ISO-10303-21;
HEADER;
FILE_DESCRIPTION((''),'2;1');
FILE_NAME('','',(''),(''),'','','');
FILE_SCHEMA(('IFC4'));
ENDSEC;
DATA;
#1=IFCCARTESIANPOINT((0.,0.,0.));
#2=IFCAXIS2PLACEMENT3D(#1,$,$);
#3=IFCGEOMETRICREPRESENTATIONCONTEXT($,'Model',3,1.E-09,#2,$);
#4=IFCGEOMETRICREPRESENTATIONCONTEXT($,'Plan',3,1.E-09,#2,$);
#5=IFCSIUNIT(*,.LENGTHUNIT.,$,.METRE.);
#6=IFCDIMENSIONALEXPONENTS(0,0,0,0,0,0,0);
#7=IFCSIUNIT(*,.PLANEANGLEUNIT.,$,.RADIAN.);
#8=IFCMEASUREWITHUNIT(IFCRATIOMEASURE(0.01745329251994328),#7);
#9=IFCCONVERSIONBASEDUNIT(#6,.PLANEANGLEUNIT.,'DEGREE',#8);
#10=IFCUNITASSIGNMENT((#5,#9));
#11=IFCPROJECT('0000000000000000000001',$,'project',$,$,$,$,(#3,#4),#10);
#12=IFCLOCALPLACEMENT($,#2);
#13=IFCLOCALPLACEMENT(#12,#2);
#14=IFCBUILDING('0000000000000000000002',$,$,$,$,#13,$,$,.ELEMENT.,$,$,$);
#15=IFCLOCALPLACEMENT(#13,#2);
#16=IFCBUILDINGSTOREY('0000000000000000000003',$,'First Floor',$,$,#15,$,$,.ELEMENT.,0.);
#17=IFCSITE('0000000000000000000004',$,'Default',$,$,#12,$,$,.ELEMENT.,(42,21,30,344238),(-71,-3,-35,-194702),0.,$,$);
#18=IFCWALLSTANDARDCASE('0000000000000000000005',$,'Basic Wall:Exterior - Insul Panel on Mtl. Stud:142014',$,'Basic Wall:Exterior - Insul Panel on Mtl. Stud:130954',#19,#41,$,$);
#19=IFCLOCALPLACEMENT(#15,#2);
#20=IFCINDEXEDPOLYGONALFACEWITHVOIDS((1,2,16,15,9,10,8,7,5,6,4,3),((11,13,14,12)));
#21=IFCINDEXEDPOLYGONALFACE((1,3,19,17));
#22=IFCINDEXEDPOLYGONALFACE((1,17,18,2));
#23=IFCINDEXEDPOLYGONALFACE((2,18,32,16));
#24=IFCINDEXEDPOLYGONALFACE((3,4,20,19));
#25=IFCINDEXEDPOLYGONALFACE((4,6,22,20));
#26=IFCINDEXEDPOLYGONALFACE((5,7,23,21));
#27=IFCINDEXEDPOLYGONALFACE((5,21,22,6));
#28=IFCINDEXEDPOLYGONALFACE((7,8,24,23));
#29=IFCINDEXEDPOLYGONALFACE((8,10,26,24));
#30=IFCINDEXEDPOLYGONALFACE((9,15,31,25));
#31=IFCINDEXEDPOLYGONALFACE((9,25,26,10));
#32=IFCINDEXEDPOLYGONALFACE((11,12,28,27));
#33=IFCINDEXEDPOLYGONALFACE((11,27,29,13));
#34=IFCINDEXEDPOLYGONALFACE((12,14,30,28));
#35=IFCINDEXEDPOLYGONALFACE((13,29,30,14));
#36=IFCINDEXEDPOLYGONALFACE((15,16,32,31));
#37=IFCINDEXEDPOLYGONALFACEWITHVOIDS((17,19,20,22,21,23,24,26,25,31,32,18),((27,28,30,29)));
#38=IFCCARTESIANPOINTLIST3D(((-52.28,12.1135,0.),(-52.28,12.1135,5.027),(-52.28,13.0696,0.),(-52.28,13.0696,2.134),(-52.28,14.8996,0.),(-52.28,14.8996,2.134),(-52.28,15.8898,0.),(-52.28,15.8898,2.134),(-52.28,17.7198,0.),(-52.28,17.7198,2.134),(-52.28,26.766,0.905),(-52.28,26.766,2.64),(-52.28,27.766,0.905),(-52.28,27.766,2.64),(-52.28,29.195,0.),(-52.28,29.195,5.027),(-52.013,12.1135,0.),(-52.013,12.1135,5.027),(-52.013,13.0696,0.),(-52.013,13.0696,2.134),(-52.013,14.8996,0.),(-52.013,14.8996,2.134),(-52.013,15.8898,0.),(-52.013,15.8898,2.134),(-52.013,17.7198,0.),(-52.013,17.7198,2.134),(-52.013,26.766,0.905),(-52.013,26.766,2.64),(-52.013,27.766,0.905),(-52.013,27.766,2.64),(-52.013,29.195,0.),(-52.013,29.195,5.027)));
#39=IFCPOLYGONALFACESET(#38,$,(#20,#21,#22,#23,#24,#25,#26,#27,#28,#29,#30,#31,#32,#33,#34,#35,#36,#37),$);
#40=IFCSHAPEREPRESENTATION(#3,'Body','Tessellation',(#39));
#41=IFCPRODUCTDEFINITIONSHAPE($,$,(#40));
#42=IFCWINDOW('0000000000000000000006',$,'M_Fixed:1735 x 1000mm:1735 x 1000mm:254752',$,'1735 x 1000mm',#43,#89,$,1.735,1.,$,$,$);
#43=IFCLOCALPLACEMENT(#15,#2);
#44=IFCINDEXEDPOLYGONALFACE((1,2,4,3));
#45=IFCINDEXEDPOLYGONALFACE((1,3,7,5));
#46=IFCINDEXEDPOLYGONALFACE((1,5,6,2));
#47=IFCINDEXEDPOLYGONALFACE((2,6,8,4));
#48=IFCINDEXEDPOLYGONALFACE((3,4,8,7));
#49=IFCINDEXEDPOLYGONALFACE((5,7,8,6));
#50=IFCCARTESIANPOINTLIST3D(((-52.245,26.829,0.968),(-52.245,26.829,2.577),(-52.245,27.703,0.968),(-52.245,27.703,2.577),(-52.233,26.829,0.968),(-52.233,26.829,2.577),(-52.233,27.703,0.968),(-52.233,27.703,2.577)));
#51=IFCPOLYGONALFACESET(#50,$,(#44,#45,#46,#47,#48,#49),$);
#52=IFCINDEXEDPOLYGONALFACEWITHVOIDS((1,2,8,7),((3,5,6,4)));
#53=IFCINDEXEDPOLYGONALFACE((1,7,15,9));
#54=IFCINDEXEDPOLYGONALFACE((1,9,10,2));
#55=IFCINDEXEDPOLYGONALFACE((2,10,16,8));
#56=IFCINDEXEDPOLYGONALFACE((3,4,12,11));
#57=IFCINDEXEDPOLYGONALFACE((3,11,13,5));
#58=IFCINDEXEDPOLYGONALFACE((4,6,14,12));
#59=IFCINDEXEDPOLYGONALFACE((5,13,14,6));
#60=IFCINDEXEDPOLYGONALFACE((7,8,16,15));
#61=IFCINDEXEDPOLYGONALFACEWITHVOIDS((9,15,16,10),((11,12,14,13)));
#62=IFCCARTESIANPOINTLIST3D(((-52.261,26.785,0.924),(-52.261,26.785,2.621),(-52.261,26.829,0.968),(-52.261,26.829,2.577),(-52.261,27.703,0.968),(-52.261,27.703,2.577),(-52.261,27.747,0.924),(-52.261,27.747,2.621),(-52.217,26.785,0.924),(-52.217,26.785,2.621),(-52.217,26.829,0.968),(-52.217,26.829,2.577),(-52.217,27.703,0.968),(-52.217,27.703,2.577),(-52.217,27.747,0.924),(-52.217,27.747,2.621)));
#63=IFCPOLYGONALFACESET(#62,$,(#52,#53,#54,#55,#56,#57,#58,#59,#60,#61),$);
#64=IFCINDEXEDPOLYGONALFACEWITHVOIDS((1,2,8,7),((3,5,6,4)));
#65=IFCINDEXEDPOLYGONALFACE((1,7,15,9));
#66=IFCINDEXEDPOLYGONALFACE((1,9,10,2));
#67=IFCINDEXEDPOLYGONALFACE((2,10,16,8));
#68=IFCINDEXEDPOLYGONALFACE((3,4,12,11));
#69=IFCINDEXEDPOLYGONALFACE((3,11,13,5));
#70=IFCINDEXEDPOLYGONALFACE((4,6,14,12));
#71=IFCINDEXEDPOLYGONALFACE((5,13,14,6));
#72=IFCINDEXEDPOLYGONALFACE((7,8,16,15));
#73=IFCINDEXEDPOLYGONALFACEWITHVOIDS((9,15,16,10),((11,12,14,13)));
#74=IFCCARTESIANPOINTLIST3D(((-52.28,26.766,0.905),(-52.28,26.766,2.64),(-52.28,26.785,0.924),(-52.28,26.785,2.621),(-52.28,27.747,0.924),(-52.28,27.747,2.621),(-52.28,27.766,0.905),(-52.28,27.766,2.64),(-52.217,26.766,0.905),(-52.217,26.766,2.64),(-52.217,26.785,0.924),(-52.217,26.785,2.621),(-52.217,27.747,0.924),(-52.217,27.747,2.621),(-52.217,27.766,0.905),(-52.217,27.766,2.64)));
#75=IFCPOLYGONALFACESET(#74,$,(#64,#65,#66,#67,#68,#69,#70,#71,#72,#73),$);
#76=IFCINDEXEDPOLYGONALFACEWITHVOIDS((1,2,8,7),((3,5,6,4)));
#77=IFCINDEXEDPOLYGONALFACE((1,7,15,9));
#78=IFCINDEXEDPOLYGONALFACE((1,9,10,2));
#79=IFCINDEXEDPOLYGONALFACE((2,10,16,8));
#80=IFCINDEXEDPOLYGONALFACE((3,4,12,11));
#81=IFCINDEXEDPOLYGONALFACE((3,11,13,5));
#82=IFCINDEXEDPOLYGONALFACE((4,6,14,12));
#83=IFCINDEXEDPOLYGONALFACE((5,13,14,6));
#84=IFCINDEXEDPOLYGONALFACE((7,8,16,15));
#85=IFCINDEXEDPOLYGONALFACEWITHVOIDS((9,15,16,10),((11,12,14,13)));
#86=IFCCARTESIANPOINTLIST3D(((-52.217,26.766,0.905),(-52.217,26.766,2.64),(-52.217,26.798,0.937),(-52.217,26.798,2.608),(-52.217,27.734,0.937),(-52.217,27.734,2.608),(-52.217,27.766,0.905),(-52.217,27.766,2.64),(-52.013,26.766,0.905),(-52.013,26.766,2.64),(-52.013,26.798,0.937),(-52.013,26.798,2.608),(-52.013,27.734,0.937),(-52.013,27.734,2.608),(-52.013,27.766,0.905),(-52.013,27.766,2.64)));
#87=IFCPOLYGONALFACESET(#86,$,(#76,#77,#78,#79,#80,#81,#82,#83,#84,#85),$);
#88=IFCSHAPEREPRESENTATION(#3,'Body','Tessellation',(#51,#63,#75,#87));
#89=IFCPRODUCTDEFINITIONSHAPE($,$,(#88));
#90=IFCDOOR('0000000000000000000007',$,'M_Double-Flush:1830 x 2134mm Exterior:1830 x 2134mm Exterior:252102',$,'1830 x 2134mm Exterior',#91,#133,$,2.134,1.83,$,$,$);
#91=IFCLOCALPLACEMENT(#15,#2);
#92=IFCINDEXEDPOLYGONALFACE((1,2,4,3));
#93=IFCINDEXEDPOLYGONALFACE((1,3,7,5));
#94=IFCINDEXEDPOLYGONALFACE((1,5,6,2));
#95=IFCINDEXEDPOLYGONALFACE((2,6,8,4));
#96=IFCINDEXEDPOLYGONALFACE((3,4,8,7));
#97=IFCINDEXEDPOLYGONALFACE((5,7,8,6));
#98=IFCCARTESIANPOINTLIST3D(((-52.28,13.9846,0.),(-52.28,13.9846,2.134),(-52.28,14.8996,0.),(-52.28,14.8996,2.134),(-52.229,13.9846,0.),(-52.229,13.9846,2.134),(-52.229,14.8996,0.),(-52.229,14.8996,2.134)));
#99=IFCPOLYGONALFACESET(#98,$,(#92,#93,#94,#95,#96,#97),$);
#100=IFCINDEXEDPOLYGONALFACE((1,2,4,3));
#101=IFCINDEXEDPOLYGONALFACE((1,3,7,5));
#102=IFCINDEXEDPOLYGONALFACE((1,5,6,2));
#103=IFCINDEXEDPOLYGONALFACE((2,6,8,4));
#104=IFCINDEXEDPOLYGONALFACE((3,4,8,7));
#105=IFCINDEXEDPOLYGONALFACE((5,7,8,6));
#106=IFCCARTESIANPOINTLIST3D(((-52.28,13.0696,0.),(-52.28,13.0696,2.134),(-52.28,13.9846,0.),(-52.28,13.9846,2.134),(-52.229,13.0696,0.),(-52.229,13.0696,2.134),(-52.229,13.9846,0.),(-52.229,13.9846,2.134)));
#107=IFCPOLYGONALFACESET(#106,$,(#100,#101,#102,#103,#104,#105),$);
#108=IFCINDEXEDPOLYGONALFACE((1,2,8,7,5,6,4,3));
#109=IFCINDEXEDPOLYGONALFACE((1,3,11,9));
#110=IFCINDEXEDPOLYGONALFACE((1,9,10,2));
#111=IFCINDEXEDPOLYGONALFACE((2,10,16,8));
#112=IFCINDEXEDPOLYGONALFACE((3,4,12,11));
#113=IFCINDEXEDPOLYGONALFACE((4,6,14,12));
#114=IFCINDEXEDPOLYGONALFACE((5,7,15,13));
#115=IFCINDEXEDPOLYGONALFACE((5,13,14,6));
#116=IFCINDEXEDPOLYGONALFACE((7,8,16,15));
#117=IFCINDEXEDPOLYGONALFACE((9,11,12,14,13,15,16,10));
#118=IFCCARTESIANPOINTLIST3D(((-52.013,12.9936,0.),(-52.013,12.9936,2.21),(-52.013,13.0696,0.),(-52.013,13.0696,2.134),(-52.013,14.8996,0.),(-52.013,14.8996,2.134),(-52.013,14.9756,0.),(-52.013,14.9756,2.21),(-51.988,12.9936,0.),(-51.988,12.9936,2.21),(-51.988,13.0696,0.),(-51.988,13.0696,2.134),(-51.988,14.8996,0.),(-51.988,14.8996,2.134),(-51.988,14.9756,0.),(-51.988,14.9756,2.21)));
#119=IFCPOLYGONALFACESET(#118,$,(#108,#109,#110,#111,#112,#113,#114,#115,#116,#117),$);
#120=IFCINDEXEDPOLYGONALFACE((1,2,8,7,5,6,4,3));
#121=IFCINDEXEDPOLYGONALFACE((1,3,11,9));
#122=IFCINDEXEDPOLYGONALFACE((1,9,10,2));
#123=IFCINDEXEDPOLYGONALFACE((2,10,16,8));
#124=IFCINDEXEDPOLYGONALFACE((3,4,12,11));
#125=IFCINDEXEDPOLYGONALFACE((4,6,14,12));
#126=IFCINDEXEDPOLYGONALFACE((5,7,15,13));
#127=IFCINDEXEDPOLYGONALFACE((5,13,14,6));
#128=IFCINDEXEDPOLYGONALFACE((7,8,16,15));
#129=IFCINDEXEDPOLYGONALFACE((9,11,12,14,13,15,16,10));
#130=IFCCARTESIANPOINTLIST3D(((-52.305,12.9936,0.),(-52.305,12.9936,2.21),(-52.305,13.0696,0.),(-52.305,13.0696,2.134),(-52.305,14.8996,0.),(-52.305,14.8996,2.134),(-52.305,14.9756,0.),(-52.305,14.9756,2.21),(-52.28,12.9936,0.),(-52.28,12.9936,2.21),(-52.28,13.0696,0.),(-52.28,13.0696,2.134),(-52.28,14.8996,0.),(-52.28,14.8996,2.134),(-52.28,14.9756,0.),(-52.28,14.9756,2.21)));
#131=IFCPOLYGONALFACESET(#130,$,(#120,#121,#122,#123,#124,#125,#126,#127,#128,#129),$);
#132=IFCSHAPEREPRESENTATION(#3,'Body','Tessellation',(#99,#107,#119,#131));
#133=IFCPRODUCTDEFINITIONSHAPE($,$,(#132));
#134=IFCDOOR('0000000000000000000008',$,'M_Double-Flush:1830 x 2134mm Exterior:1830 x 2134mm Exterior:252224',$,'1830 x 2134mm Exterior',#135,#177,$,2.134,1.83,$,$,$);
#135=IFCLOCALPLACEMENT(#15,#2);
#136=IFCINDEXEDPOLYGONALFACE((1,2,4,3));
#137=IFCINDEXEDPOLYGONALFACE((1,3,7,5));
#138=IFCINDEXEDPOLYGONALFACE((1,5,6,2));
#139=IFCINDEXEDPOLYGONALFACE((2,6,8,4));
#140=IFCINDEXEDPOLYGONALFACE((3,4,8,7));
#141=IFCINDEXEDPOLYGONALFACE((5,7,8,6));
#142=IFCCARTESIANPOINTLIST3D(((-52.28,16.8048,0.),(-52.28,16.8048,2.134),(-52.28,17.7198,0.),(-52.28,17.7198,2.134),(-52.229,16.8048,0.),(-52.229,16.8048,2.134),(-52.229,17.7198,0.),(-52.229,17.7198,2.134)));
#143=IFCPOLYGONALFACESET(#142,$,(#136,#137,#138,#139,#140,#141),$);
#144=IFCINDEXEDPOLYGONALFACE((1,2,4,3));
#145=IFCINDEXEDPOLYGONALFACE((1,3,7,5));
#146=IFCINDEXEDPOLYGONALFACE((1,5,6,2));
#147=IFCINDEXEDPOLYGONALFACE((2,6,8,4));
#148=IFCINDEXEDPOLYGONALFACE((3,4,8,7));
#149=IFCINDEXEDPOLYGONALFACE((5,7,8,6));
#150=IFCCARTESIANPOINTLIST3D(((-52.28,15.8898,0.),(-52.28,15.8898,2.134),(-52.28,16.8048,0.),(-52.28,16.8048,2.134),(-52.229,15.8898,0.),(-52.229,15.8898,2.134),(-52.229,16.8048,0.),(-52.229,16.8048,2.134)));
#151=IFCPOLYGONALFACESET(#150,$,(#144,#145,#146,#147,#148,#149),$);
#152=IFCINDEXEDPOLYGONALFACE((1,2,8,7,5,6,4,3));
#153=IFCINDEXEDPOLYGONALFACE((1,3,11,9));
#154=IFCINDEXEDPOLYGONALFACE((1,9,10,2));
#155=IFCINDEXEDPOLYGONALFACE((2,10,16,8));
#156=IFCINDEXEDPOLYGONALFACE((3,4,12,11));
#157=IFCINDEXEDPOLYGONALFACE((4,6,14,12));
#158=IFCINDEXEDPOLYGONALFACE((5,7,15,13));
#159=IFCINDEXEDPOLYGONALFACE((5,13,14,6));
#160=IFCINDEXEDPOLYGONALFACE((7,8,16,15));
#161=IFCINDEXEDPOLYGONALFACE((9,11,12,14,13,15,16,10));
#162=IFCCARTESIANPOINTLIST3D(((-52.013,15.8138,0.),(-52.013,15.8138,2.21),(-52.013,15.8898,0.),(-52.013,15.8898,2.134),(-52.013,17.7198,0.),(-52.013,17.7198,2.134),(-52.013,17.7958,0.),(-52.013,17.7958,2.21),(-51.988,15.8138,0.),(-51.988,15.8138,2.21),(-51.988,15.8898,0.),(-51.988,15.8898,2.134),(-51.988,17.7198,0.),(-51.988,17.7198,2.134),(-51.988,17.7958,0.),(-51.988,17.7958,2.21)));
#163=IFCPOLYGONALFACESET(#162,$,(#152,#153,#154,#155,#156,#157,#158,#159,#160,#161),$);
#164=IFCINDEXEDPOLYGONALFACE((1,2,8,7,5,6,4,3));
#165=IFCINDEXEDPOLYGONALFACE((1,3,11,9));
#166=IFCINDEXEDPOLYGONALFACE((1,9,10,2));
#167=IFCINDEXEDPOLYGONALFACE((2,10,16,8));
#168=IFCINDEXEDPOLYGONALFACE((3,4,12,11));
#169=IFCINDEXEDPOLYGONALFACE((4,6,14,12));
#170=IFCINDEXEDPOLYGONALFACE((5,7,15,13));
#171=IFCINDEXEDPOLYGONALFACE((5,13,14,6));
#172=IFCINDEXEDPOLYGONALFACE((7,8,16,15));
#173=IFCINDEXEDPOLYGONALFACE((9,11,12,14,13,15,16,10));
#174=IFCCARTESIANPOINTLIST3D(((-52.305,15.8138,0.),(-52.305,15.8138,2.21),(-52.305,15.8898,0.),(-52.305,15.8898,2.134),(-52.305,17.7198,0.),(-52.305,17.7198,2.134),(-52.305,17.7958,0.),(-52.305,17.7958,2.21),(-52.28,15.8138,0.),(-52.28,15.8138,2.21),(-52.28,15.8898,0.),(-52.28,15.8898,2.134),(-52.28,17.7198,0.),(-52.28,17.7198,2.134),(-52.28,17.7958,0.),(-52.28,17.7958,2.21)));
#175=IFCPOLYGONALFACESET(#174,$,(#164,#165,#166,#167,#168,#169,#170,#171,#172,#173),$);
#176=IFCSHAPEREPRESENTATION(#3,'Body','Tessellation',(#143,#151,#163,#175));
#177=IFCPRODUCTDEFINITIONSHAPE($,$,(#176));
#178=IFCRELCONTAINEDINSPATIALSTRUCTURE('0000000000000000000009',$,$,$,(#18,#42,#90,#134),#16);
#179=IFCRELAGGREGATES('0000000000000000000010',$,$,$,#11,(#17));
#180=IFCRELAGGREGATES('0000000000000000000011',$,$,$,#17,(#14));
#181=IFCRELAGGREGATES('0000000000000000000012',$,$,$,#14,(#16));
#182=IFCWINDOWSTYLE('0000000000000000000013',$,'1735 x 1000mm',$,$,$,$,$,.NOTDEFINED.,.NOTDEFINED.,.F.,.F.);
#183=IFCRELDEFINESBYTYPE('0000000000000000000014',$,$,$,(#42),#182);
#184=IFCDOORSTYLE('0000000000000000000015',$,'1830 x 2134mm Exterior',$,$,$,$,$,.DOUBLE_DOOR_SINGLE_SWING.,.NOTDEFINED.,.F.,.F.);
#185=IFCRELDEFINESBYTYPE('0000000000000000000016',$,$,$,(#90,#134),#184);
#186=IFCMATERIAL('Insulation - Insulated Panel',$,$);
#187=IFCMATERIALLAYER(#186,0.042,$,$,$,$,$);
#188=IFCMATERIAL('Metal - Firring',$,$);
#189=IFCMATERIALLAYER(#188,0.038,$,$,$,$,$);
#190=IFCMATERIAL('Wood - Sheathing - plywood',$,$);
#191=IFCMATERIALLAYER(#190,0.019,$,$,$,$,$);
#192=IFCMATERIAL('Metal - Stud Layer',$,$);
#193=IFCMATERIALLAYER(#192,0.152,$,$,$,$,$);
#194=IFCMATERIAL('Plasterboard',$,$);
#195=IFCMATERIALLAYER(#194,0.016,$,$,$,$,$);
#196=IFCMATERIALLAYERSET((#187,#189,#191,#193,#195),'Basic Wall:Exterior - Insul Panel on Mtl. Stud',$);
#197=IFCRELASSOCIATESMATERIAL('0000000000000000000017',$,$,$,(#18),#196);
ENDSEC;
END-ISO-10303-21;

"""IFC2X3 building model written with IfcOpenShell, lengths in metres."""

from ifc_helpers import new_model, entity, si_unit, converted_unit, frame, frame_2d, origin, origin_2d_with_axis, place, context, project, spatial, polyline, rectangle, outline, extrude, source, transform, mapped, material, layer, layer_set, layer_usage, type_object, type_shapes, element, fill, save


model = new_model("IFC2X3")

# Units and contexts
model_context = context("Model", 3, precision=1e-09, world=origin())
plan_context = context("Plan", 3, precision=1e-09, world=origin())
ifc_project = project(units=[si_unit("LENGTHUNIT", "METRE"), converted_unit("PLANEANGLEUNIT", "DEGREE", entity("IfcRatioMeasure", 0.01745329251994328), si_unit("PLANEANGLEUNIT", "RADIAN"), dimensions=[0, 0, 0, 0, 0, 0, 0])], contexts=[model_context, plan_context])

# Site, building, storey
site_placement = place(None, origin())
site = spatial("IfcSite", under=ifc_project, at=site_placement, Name="Default", CompositionType="ELEMENT", RefLatitude=(42, 21, 30, 344238), RefLongitude=(-71, -3, -35, -194702), RefElevation=0.0)
building_placement = place(site_placement, origin())
building = spatial("IfcBuilding", under=site, at=building_placement, CompositionType="ELEMENT")
storey_placement = place(building_placement, origin())
storey = spatial("IfcBuildingStorey", under=building, at=storey_placement, Name="First Floor", CompositionType="ELEMENT", Elevation=0.0)

# Wall, openings, window, doors
ifc_material_1 = material(Name="Insulation - Insulated Panel")
ifc_layer_1 = layer(ifc_material_1, 0.042)
ifc_material_2 = material(Name="Metal - Firring")
ifc_layer_2 = layer(ifc_material_2, 0.038)
ifc_material_3 = material(Name="Wood - Sheathing - plywood")
ifc_layer_3 = layer(ifc_material_3, 0.019)
ifc_material_4 = material(Name="Metal - Stud Layer")
ifc_layer_4 = layer(ifc_material_4, 0.152)
ifc_material_5 = material(Name="Plasterboard")
ifc_layer_5 = layer(ifc_material_5, 0.016)
ifc_layer_set_1 = layer_set([ifc_layer_1, ifc_layer_2, ifc_layer_3, ifc_layer_4, ifc_layer_5], Name="Basic Wall:Exterior - Insul Panel on Mtl. Stud")
ifc_layer_usage_1 = layer_usage(ifc_layer_set_1, "AXIS2", "NEGATIVE", 0.1335)
wall_1_placement = place(storey_placement, frame((-52.1465, 12.1135, 0.0), z_axis=(0.0, 0.0, 1.0), x_axis=(0.0, 1.0, 0.0)))
wall_1 = element("IfcWallStandardCase", 1, at=wall_1_placement, inside=storey, material=ifc_layer_usage_1, Name="Basic Wall:Exterior - Insul Panel on Mtl. Stud:142014", ObjectType="Basic Wall:Exterior - Insul Panel on Mtl. Stud:130954", context=model_context, shape_type="SweptSolid", body=[
    extrude(rectangle(XDim=17.0815, YDim=0.267, at=frame_2d((8.5407, 0.0), x_axis=(1.0, 0.0))), origin(), (0.0, 0.0, 1.0), 5.027),
])
opening_1_placement = place(wall_1_placement, frame((14.6525, -0.1335, 0.905)))
opening_1 = element("IfcOpeningElement", 2, at=opening_1_placement, cuts=wall_1, ObjectType="Opening", context=model_context, shape_type="SweptSolid", body=[
    extrude(rectangle(XDim=1.735, YDim=1.0, at=frame_2d((0.8675, 0.5), x_axis=(1.0, 0.0))), frame((0.0, 0.0, 0.0), z_axis=(0.0, 1.0, 0.0), x_axis=(0.0, 0.0, 1.0)), (0.0, 0.0, 1.0), 0.267),
])
opening_2_placement = place(wall_1_placement, frame((0.9561, -0.1335, 0.0)))
opening_2 = element("IfcOpeningElement", 3, at=opening_2_placement, cuts=wall_1, ObjectType="Opening", context=model_context, shape_type="SweptSolid", body=[
    extrude(rectangle(XDim=2.134, YDim=1.83, at=frame_2d((1.067, 0.915), x_axis=(1.0, 0.0))), frame((0.0, 0.0, 0.0), z_axis=(0.0, 1.0, 0.0), x_axis=(0.0, 0.0, 1.0)), (0.0, 0.0, 1.0), 0.267),
])
opening_3_placement = place(wall_1_placement, frame((3.7763, -0.1335, 0.0)))
opening_3 = element("IfcOpeningElement", 4, at=opening_3_placement, cuts=wall_1, ObjectType="Opening", context=model_context, shape_type="SweptSolid", body=[
    extrude(rectangle(XDim=2.134, YDim=1.83, at=frame_2d((1.067, 0.915), x_axis=(1.0, 0.0))), frame((0.0, 0.0, 0.0), z_axis=(0.0, 1.0, 0.0), x_axis=(0.0, 0.0, 1.0)), (0.0, 0.0, 1.0), 0.267),
])
window_style = type_object("IfcWindowStyle", Name="1735 x 1000mm", ConstructionType="NOTDEFINED", OperationType="NOTDEFINED", ParameterTakesPrecedence=False, Sizeable=False)
shared_shape_1 = source(origin(), model_context, "Body", "SweptSolid", [
    extrude(rectangle(XDim=0.012, YDim=0.874, at=origin_2d_with_axis()), frame((0.5, 0.226, 0.063), z_axis=(0.0, 0.0, 1.0), x_axis=(0.0, -1.0, 0.0)), (0.0, 0.0, 1.0), 1.609),
    extrude(outline(polyline([(-0.481, -0.8485), (0.481, -0.8485), (0.481, 0.8485), (-0.481, 0.8485), (-0.481, -0.8485)]), holes=[polyline([(-0.437, -0.8045), (-0.437, 0.8045), (0.437, 0.8045), (0.437, -0.8045), (-0.437, -0.8045)])]), frame((0.5, 0.204, 0.8675), z_axis=(0.0, 1.0, 0.0), x_axis=(1.0, 0.0, 0.0)), (0.0, 0.0, 1.0), 0.044),
    extrude(outline(polyline([(-0.5, -0.8675), (0.5, -0.8675), (0.5, 0.8675), (-0.5, 0.8675), (-0.5, -0.8675)]), holes=[polyline([(-0.481, -0.8485), (-0.481, 0.8485), (0.481, 0.8485), (0.481, -0.8485), (-0.481, -0.8485)])]), frame((0.5, 0.204, 0.8675), z_axis=(0.0, 1.0, 0.0), x_axis=(1.0, 0.0, 0.0)), (0.0, 0.0, 1.0), 0.063),
    extrude(outline(polyline([(-0.5, -0.8675), (0.5, -0.8675), (0.5, 0.8675), (-0.5, 0.8675), (-0.5, -0.8675)]), holes=[polyline([(-0.468, -0.8355), (-0.468, 0.8355), (0.468, 0.8355), (0.468, -0.8355), (-0.468, -0.8355)])]), frame((0.5, 0.0, 0.8675), z_axis=(0.0, 1.0, 0.0), x_axis=(1.0, 0.0, 0.0)), (0.0, 0.0, 1.0), 0.204),
])
type_shapes(window_style, [shared_shape_1])
window_placement = place(opening_1_placement, origin())
window = element("IfcWindow", 5, at=window_placement, inside=storey, type_object=window_style, Name="M_Fixed:1735 x 1000mm:1735 x 1000mm:254752", ObjectType="1735 x 1000mm", OverallHeight=1.735, OverallWidth=1.0, context=model_context, shape_type="MappedRepresentation", body=[
    mapped(shared_shape_1, transform((0.0, 0.0, 0.0), scale=1.0)),
])
fill(opening_1, window)
door_style_1 = type_object("IfcDoorStyle", Name="1830 x 2134mm Exterior", ConstructionType="NOTDEFINED", OperationType="DOUBLE_DOOR_SINGLE_SWING", ParameterTakesPrecedence=False, Sizeable=False)
shared_shape_2 = source(origin(), model_context, "Body", "SweptSolid", [
    extrude(rectangle(XDim=0.051, YDim=0.915, at=origin_2d_with_axis()), frame((1.3725, 0.2415, 0.0), z_axis=(0.0, 0.0, 1.0), x_axis=(0.0, -1.0, 0.0)), (0.0, 0.0, 1.0), 2.134),
    extrude(rectangle(XDim=0.051, YDim=0.915, at=origin_2d_with_axis()), frame((0.4575, 0.2415, 0.0), z_axis=(0.0, 0.0, 1.0), x_axis=(0.0, -1.0, 0.0)), (0.0, 0.0, 1.0), 2.134),
    extrude(outline(polyline([(-1.048, 0.915), (1.086, 0.915), (1.086, 0.991), (-1.124, 0.991), (-1.124, -0.991), (1.086, -0.991), (1.086, -0.915), (-1.048, -0.915), (-1.048, 0.915)])), frame((0.915, -0.025, 1.086), z_axis=(0.0, 1.0, 0.0), x_axis=(0.0, 0.0, -1.0)), (0.0, 0.0, 1.0), 0.025),
    extrude(outline(polyline([(-1.048, 0.915), (1.086, 0.915), (1.086, 0.991), (-1.124, 0.991), (-1.124, -0.991), (1.086, -0.991), (1.086, -0.915), (-1.048, -0.915), (-1.048, 0.915)])), frame((0.915, 0.267, 1.086), z_axis=(0.0, 1.0, 0.0), x_axis=(0.0, 0.0, -1.0)), (0.0, 0.0, 1.0), 0.025),
])
type_shapes(door_style_1, [shared_shape_2])
door_1_placement = place(opening_2_placement, origin())
door_1 = element("IfcDoor", 6, at=door_1_placement, inside=storey, type_object=door_style_1, Name="M_Double-Flush:1830 x 2134mm Exterior:1830 x 2134mm Exterior:252102", ObjectType="1830 x 2134mm Exterior", OverallHeight=2.134, OverallWidth=1.83, context=model_context, shape_type="MappedRepresentation", body=[
    mapped(shared_shape_2, transform((0.0, 0.0, 0.0), scale=1.0)),
])
fill(opening_2, door_1)
door_2_placement = place(opening_3_placement, origin())
door_2 = element("IfcDoor", 7, at=door_2_placement, inside=storey, type_object=door_style_1, Name="M_Double-Flush:1830 x 2134mm Exterior:1830 x 2134mm Exterior:252224", ObjectType="1830 x 2134mm Exterior", OverallHeight=2.134, OverallWidth=1.83, context=model_context, shape_type="MappedRepresentation", body=[
    mapped(shared_shape_2, transform((0.0, 0.0, 0.0), scale=1.0)),
])
fill(opening_3, door_2)

save(model, "model.ifc")
